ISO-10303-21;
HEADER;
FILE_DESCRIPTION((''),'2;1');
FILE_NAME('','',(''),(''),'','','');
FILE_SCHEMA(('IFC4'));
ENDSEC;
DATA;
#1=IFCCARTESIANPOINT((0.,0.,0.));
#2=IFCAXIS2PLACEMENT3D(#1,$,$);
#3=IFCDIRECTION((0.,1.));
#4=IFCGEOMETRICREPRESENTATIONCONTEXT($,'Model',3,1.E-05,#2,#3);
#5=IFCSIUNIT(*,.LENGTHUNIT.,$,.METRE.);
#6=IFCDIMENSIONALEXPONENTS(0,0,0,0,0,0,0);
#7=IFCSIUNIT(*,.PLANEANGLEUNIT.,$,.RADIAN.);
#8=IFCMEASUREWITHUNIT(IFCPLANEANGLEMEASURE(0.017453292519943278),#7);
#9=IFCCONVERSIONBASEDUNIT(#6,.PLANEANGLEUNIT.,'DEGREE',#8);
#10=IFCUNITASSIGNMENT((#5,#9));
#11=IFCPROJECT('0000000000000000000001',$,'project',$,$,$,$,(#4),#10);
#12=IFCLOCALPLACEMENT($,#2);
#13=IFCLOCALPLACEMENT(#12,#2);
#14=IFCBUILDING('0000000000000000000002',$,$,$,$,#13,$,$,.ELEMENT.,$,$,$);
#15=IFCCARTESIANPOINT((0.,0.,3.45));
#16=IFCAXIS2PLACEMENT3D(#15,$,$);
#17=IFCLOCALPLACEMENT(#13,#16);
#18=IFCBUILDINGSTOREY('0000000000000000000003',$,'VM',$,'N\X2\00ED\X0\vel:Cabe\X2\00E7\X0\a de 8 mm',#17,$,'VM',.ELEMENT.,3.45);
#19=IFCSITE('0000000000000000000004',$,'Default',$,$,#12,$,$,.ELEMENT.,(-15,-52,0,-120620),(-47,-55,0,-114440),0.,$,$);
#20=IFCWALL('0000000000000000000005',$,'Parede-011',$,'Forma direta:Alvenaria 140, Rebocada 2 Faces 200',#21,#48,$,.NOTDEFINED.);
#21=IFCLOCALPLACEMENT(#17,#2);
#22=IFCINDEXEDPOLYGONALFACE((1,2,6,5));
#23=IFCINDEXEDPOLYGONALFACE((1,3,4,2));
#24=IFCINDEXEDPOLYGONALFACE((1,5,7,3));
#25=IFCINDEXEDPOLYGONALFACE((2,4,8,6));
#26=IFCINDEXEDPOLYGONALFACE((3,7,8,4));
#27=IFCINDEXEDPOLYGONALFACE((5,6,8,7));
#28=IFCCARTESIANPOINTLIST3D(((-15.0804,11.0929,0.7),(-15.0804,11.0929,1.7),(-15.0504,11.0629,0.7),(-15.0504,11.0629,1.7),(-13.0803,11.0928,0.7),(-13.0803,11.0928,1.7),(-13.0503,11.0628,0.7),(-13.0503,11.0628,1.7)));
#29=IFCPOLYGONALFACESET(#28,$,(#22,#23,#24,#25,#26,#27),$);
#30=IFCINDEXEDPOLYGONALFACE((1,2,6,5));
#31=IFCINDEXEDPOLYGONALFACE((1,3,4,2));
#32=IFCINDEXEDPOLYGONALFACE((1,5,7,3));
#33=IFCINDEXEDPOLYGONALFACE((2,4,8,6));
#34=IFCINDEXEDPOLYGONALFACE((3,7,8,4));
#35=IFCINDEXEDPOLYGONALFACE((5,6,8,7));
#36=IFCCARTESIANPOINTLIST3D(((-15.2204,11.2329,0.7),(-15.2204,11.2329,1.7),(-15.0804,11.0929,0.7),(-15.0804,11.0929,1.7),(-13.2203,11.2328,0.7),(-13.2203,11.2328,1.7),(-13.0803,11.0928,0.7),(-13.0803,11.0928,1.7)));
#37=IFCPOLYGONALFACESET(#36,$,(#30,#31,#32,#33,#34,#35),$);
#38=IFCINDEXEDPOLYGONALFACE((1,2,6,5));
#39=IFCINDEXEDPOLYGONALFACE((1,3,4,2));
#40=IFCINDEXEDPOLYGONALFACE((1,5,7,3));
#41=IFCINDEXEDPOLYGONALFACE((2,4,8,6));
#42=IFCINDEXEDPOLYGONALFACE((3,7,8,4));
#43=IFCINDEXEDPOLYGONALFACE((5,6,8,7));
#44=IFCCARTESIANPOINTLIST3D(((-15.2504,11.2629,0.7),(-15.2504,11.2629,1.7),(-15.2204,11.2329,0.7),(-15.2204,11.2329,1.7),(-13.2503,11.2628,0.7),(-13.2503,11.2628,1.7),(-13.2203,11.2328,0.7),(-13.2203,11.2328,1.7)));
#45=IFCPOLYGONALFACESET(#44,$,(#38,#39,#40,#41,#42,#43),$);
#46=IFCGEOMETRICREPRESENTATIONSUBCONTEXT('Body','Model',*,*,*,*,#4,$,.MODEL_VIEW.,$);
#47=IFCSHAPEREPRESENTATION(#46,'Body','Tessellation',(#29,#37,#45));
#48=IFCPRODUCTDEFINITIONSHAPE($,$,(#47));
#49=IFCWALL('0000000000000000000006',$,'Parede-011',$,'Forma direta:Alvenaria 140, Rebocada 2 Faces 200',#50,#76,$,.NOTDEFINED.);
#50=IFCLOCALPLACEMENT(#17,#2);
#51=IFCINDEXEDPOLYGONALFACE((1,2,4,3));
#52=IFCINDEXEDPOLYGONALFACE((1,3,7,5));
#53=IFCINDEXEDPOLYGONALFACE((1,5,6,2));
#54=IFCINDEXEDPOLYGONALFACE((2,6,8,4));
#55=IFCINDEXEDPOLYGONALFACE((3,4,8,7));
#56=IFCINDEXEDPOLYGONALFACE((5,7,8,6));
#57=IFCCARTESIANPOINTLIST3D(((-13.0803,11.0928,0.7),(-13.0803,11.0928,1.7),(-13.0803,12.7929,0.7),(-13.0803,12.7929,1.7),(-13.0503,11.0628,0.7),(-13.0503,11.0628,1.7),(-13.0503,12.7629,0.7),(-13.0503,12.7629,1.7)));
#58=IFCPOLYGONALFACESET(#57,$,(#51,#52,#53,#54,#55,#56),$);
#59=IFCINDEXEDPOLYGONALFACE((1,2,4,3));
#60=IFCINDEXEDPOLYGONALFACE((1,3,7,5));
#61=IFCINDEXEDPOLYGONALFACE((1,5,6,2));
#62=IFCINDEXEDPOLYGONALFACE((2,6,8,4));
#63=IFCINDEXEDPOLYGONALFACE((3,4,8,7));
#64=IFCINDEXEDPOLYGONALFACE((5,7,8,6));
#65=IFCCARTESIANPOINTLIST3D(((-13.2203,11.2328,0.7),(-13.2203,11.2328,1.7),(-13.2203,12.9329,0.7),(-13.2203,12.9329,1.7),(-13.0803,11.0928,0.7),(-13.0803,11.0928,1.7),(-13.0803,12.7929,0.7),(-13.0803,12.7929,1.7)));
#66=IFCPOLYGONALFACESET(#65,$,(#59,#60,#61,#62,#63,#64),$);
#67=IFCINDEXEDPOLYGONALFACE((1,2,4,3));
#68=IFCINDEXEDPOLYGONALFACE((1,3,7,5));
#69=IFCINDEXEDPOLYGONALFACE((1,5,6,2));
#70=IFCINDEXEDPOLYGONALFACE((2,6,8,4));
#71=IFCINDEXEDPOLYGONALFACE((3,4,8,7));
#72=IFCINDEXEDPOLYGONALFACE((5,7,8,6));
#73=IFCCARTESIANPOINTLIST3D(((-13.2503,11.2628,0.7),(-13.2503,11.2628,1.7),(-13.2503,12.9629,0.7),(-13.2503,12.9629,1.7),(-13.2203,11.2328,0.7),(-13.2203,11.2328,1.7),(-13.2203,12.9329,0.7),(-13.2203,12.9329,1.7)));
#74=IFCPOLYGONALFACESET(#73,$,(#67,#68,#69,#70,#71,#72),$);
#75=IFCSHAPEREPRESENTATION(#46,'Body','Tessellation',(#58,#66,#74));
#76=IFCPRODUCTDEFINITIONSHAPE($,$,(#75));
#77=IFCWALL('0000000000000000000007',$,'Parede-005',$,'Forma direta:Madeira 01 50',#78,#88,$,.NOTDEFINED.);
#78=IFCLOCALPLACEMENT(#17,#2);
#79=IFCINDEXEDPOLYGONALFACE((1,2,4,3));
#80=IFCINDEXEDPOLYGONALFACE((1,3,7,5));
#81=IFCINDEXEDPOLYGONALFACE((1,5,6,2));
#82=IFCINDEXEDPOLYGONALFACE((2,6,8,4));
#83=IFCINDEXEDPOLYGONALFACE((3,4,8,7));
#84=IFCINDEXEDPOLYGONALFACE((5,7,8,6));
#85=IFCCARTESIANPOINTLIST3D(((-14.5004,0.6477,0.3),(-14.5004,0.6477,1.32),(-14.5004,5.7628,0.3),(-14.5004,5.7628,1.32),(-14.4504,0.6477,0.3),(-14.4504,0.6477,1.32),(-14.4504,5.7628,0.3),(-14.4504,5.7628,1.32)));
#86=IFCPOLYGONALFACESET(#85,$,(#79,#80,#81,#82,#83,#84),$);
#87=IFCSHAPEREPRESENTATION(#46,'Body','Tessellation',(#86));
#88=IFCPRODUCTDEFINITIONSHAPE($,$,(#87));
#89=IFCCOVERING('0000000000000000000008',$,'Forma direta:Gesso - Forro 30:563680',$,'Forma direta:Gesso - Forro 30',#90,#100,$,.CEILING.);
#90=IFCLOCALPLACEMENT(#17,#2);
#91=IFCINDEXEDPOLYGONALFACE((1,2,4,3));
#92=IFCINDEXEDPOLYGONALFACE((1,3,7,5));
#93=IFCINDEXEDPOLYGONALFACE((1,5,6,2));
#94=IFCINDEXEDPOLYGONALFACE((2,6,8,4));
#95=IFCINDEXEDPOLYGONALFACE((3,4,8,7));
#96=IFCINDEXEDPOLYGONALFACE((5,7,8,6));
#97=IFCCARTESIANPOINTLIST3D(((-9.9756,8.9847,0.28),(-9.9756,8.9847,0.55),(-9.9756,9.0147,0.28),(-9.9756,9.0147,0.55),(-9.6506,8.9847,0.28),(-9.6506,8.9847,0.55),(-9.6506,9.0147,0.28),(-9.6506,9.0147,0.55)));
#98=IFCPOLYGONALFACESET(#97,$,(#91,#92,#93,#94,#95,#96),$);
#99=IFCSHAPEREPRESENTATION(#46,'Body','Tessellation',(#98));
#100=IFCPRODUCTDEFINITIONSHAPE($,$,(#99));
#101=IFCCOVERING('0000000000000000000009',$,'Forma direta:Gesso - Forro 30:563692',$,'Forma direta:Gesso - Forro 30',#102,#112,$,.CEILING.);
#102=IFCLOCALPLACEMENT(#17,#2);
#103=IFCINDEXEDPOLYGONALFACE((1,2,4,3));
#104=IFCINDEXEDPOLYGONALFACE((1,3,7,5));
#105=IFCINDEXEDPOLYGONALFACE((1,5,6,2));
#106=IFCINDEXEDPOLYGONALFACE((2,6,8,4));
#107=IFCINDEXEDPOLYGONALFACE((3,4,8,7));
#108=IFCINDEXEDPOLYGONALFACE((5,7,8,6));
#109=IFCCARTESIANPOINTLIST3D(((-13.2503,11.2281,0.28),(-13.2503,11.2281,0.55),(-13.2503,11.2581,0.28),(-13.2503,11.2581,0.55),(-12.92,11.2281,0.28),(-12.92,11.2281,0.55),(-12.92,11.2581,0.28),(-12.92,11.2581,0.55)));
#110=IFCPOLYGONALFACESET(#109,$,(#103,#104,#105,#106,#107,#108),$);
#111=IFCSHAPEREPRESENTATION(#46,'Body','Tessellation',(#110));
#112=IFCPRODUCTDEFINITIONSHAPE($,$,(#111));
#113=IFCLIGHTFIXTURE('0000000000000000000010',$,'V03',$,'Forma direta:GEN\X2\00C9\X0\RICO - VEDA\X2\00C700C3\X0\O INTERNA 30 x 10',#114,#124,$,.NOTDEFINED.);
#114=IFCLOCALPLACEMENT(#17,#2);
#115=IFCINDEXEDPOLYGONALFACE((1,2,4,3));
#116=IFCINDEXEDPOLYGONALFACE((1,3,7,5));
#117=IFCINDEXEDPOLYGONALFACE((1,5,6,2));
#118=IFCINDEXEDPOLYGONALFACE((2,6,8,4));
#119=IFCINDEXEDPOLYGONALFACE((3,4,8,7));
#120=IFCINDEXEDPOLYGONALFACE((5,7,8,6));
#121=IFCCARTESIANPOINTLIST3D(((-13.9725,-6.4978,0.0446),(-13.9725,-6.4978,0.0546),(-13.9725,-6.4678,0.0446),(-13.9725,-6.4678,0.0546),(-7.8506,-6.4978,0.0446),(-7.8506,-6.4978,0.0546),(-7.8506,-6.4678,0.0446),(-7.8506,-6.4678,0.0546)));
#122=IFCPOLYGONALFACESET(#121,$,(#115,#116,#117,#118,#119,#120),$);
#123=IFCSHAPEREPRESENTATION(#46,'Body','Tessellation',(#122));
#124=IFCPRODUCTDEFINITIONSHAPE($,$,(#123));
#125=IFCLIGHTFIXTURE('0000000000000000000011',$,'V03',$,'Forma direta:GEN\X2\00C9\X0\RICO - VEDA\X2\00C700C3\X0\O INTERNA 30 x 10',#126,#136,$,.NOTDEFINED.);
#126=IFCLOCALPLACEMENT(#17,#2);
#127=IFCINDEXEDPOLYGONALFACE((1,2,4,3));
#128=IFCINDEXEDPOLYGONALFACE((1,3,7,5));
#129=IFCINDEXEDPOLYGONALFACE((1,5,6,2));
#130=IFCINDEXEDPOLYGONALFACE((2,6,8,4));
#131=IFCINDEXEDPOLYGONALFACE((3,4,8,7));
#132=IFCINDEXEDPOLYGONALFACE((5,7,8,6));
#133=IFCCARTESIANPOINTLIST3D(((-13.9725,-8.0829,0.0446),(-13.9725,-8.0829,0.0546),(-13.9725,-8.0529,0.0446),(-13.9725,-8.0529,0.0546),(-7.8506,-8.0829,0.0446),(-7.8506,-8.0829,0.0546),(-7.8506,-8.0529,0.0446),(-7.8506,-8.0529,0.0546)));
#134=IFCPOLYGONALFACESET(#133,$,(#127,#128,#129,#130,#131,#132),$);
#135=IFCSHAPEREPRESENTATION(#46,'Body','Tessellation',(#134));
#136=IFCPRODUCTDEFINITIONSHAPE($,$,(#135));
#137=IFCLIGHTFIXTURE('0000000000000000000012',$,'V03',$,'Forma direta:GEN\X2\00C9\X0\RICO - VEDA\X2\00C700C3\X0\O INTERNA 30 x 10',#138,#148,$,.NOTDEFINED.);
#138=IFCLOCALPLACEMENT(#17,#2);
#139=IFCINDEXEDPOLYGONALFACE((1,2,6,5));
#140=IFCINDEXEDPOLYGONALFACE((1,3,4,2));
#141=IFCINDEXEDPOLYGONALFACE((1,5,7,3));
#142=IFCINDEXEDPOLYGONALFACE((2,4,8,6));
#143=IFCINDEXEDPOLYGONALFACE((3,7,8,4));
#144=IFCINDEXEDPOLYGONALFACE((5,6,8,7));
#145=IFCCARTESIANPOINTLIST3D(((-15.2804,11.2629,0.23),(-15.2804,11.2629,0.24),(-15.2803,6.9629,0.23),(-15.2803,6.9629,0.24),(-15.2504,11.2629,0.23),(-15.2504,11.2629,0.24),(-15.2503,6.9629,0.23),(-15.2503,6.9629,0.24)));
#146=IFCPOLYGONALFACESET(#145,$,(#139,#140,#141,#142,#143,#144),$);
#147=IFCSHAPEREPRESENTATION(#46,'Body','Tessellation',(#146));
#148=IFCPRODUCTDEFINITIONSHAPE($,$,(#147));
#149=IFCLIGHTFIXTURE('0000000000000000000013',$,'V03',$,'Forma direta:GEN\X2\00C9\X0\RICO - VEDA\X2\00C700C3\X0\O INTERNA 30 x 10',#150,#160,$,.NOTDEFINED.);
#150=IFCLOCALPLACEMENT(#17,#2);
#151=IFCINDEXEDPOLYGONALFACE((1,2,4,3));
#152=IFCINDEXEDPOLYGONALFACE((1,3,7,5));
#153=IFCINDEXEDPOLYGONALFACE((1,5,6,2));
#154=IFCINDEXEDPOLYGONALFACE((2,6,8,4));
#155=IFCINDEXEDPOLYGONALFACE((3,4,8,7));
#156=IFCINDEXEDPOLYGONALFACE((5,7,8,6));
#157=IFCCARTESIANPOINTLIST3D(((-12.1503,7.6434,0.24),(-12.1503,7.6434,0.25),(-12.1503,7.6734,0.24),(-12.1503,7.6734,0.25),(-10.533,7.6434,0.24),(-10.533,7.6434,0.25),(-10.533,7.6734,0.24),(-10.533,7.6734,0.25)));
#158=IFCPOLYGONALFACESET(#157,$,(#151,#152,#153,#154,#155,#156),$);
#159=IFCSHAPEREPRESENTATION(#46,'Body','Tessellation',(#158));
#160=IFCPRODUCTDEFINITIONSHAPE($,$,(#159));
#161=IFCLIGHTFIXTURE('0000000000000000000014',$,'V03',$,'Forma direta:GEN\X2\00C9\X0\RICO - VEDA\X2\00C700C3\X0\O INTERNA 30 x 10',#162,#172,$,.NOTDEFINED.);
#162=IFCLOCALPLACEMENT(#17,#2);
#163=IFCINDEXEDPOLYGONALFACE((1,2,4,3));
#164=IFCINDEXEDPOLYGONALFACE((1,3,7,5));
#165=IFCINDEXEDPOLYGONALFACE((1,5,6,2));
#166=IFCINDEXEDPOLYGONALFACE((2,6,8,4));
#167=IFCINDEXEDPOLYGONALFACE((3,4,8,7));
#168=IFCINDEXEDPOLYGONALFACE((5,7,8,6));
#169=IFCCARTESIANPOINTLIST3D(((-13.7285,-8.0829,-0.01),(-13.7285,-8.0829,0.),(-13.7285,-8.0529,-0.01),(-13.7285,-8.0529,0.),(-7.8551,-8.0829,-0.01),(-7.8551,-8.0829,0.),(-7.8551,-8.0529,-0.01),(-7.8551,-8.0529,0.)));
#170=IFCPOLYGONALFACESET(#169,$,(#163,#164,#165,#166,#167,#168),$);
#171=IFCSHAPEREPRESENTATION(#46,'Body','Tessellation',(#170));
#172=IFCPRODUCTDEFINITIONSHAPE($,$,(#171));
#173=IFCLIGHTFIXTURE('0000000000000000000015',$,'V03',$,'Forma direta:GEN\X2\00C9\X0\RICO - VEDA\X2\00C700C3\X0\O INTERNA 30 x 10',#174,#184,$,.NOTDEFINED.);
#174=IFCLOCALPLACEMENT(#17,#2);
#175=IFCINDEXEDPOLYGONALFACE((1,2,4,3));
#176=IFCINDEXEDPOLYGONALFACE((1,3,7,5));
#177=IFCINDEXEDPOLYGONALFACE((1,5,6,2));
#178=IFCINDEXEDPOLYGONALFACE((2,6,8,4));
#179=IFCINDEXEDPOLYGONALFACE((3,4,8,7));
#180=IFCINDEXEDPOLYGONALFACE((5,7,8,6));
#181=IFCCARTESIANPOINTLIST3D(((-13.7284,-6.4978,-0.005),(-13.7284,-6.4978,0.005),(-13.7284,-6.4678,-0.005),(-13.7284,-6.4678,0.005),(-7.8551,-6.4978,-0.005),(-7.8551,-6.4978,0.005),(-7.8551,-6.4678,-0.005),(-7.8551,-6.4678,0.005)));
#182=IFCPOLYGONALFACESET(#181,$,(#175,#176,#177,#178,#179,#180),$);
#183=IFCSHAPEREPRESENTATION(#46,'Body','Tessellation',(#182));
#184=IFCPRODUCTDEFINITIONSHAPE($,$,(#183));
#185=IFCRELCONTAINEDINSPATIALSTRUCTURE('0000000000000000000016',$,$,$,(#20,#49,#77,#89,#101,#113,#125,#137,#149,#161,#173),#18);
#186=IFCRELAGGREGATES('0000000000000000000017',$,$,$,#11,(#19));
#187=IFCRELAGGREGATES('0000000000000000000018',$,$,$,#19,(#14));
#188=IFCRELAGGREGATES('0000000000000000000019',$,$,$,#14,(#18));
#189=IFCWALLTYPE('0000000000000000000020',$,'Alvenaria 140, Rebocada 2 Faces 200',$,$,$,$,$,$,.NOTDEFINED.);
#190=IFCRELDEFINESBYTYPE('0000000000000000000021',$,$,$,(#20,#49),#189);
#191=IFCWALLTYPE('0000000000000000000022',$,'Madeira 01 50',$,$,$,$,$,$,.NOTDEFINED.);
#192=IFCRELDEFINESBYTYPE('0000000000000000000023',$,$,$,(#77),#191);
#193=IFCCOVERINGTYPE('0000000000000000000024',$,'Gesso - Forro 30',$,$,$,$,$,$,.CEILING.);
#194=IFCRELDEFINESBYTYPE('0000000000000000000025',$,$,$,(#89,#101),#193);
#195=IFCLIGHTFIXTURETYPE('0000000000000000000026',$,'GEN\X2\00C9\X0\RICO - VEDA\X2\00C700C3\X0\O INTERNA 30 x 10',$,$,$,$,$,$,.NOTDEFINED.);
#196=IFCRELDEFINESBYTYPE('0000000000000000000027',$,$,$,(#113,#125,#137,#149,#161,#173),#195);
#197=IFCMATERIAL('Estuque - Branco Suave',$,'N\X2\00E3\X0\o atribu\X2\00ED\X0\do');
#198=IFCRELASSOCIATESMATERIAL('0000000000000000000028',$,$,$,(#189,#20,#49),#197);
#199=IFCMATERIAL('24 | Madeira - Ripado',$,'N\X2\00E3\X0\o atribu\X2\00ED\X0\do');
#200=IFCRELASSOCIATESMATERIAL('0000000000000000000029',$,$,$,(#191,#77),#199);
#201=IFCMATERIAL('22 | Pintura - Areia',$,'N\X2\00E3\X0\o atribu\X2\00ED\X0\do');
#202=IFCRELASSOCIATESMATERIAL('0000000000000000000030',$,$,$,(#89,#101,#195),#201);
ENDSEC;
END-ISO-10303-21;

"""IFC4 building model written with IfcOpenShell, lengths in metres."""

from ifc_helpers import new_model, entity, si_unit, converted_unit, direction, frame, origin, place, context, subcontext, project, spatial, indexed_curve, outline, extrude, material, type_object, element, save


model = new_model("IFC4")

# Units and contexts
model_context = context("Model", 3, precision=1e-05, world=origin(), true_north=direction((0.0, 1.0)))
body_context = subcontext(model_context, "Body", "Model", "MODEL_VIEW")
ifc_project = project(units=[si_unit("LENGTHUNIT", "METRE"), converted_unit("PLANEANGLEUNIT", "DEGREE", entity("IfcPlaneAngleMeasure", 0.017453292519943278), si_unit("PLANEANGLEUNIT", "RADIAN"), dimensions=[0, 0, 0, 0, 0, 0, 0])], contexts=[model_context])

# Site, building, storey
site_placement = place(None, origin())
site = spatial("IfcSite", under=ifc_project, at=site_placement, Name="Default", CompositionType="ELEMENT", RefLatitude=(-15, -52, 0, -120620), RefLongitude=(-47, -55, 0, -114440), RefElevation=0.0)
building_placement = place(site_placement, origin())
building = spatial("IfcBuilding", under=site, at=building_placement, CompositionType="ELEMENT")
storey_placement = place(building_placement, frame((0.0, 0.0, 3.45)))
storey = spatial("IfcBuildingStorey", under=building, at=storey_placement, Name="VM", ObjectType="Nível:Cabeça de 8 mm", LongName="VM", CompositionType="ELEMENT", Elevation=3.45)

# Walls
ifc_material_1 = material(Name="Estuque - Branco Suave", Category="Não atribuído")
wall_type_1 = type_object("IfcWallType", Name="Alvenaria 140, Rebocada 2 Faces 200", PredefinedType="NOTDEFINED", material=ifc_material_1)
wall_1_placement = place(storey_placement, frame((-15.2504, 11.0628, 0.7)))
element("IfcWall", 1, at=wall_1_placement, inside=storey, type_object=wall_type_1, material=ifc_material_1, Name="Parede-011", ObjectType="Forma direta:Alvenaria 140, Rebocada 2 Faces 200", PredefinedType="NOTDEFINED", context=body_context, shape_type="SweptSolid", body=[
    extrude(outline(indexed_curve([(-0.7283, -0.7071), (-0.6859, -0.7071), (0.7283, 0.7071), (0.6859, 0.7071), (-0.7283, -0.7071)], self_intersect=False)), frame((1.185, 0.015, 0.0), z_axis=(0.0, 0.0, 1.0), x_axis=(0.707102, -0.707111, 0.0)), (0.0, 0.0, 1.0), 1.0),
    extrude(outline(indexed_curve([(-0.8061, -0.7071), (-0.6081, -0.7071), (0.8061, 0.7071), (0.6081, 0.7071), (-0.8061, -0.7071)], self_intersect=False)), frame((1.1, 0.1, 0.0), z_axis=(0.0, 0.0, 1.0), x_axis=(-0.707098, 0.707116, 0.0)), (0.0, 0.0, 1.0), 1.0),
    extrude(outline(indexed_curve([(-0.7283, -0.7071), (-0.6859, -0.7071), (0.7283, 0.7071), (0.6859, 0.7071), (-0.7283, -0.7071)], self_intersect=False)), frame((1.015, 0.185, 0.0), z_axis=(0.0, 0.0, 1.0), x_axis=(-0.707098, 0.707116, 0.0)), (0.0, 0.0, 1.0), 1.0),
])
wall_2_placement = place(storey_placement, frame((-13.2503, 11.0628, 0.7), z_axis=(0.0, 0.0, 1.0), x_axis=(0.0, 1.0, 0.0)))
element("IfcWall", 2, at=wall_2_placement, inside=storey, type_object=wall_type_1, material=ifc_material_1, Name="Parede-011", ObjectType="Forma direta:Alvenaria 140, Rebocada 2 Faces 200", PredefinedType="NOTDEFINED", context=body_context, shape_type="SweptSolid", body=[
    extrude(outline(indexed_curve([(0.5798, -0.6011), (0.6223, -0.6011), (-0.5798, 0.6011), (-0.6223, 0.6011), (0.5798, -0.6011)], self_intersect=False)), frame((0.865, -0.185, 0.0), z_axis=(0.0, 0.0, 1.0), x_axis=(-0.707116, -0.707098, 0.0)), (0.0, 0.0, 1.0), 1.0),
    extrude(outline(indexed_curve([(0.5021, -0.6011), (0.7001, -0.6011), (-0.5021, 0.6011), (-0.7001, 0.6011), (0.5021, -0.6011)], self_intersect=False)), frame((0.95, -0.1, 0.0), z_axis=(0.0, 0.0, 1.0), x_axis=(0.707116, 0.707098, 0.0)), (0.0, 0.0, 1.0), 1.0),
    extrude(outline(indexed_curve([(0.5798, -0.6011), (0.6223, -0.6011), (-0.5798, 0.6011), (-0.6223, 0.6011), (0.5798, -0.6011)], self_intersect=False)), frame((1.035, -0.015, 0.0), z_axis=(0.0, 0.0, 1.0), x_axis=(0.707116, 0.707098, 0.0)), (0.0, 0.0, 1.0), 1.0),
])
ifc_material_2 = material(Name="24 | Madeira - Ripado", Category="Não atribuído")
wall_type_2 = type_object("IfcWallType", Name="Madeira 01 50", PredefinedType="NOTDEFINED", material=ifc_material_2)
wall_3_placement = place(storey_placement, frame((-14.5004, 0.6477, 0.3), z_axis=(0.0, 0.0, 1.0), x_axis=(0.0, 1.0, 0.0)))
element("IfcWall", 3, at=wall_3_placement, inside=storey, type_object=wall_type_2, material=ifc_material_2, Name="Parede-005", ObjectType="Forma direta:Madeira 01 50", PredefinedType="NOTDEFINED", context=body_context, shape_type="SweptSolid", body=[
    extrude(outline(indexed_curve([(-0.025, -2.5576), (0.025, -2.5576), (0.025, 2.5576), (-0.025, 2.5576), (-0.025, -2.5576)], self_intersect=False)), frame((2.5576, -0.025, 0.0), z_axis=(0.0, 0.0, 1.0), x_axis=(-0.000013, -1.0, 0.0)), (0.0, 0.0, 1.0), 1.02),
])

# Coverings
ifc_material_3 = material(Name="22 | Pintura - Areia", Category="Não atribuído")
covering_type = type_object("IfcCoveringType", Name="Gesso - Forro 30", PredefinedType="CEILING")
covering_1_placement = place(storey_placement, origin())
element("IfcCovering", 4, at=covering_1_placement, inside=storey, type_object=covering_type, material=ifc_material_3, Name="Forma direta:Gesso - Forro 30:563680", ObjectType="Forma direta:Gesso - Forro 30", PredefinedType="CEILING", context=body_context, shape_type="SweptSolid", body=[
    extrude(outline(indexed_curve([(-0.015, -0.1625), (0.015, -0.1625), (0.015, 0.1625), (-0.015, 0.1625), (-0.015, -0.1625)], self_intersect=False)), frame((-9.8131, 8.9997, 0.28), z_axis=(0.0, 0.0, 1.0), x_axis=(0.000013, 1.0, 0.0)), (0.0, 0.0, 1.0), 0.27),
])
covering_2_placement = place(storey_placement, origin())
element("IfcCovering", 5, at=covering_2_placement, inside=storey, type_object=covering_type, material=ifc_material_3, Name="Forma direta:Gesso - Forro 30:563692", ObjectType="Forma direta:Gesso - Forro 30", PredefinedType="CEILING", context=body_context, shape_type="SweptSolid", body=[
    extrude(outline(indexed_curve([(-0.015, -0.1652), (0.015, -0.1652), (0.015, 0.1652), (-0.015, 0.1652), (-0.015, -0.1652)], self_intersect=False)), frame((-13.0851, 11.2431, 0.28), z_axis=(0.0, 0.0, 1.0), x_axis=(0.000002, -1.0, 0.0)), (0.0, 0.0, 1.0), 0.27),
])

# Light fixtures
light_fixture_type_1 = type_object("IfcLightFixtureType", Name="GENÉRICO - VEDAÇÃO INTERNA 30 x 10", PredefinedType="NOTDEFINED", material=ifc_material_3)
light_fixture_1_placement = place(storey_placement, origin())
element("IfcLightFixture", 6, at=light_fixture_1_placement, inside=storey, type_object=light_fixture_type_1, Name="V03", ObjectType="Forma direta:GENÉRICO - VEDAÇÃO INTERNA 30 x 10", PredefinedType="NOTDEFINED", context=body_context, shape_type="SweptSolid", body=[
    extrude(outline(indexed_curve([(-3.061, -0.015), (3.061, -0.015), (3.061, 0.015), (-3.061, 0.015), (-3.061, -0.015)], self_intersect=False)), frame((-10.9115, -6.4828, 0.0446)), (0.0, 0.0, 1.0), 0.01),
])
light_fixture_2_placement = place(storey_placement, origin())
element("IfcLightFixture", 7, at=light_fixture_2_placement, inside=storey, type_object=light_fixture_type_1, Name="V03", ObjectType="Forma direta:GENÉRICO - VEDAÇÃO INTERNA 30 x 10", PredefinedType="NOTDEFINED", context=body_context, shape_type="SweptSolid", body=[
    extrude(outline(indexed_curve([(-3.061, -0.015), (3.061, -0.015), (3.061, 0.015), (-3.061, 0.015), (-3.061, -0.015)], self_intersect=False)), frame((-10.9116, -8.0679, 0.0446)), (0.0, 0.0, 1.0), 0.01),
])
light_fixture_3_placement = place(storey_placement, origin())
element("IfcLightFixture", 8, at=light_fixture_3_placement, inside=storey, type_object=light_fixture_type_1, Name="V03", ObjectType="Forma direta:GENÉRICO - VEDAÇÃO INTERNA 30 x 10", PredefinedType="NOTDEFINED", context=body_context, shape_type="SweptSolid", body=[
    extrude(outline(indexed_curve([(-2.15, -0.015), (2.15, -0.015), (2.15, 0.015), (-2.15, 0.015), (-2.15, -0.015)], self_intersect=False)), frame((-15.2654, 9.1129, 0.23), z_axis=(0.0, 0.0, 1.0), x_axis=(-0.000001, 1.0, 0.0)), (0.0, 0.0, 1.0), 0.01),
])
light_fixture_4_placement = place(storey_placement, origin())
element("IfcLightFixture", 9, at=light_fixture_4_placement, inside=storey, type_object=light_fixture_type_1, Name="V03", ObjectType="Forma direta:GENÉRICO - VEDAÇÃO INTERNA 30 x 10", PredefinedType="NOTDEFINED", context=body_context, shape_type="SweptSolid", body=[
    extrude(outline(indexed_curve([(-0.8087, -0.015), (0.8087, -0.015), (0.8087, 0.015), (-0.8087, 0.015), (-0.8087, -0.015)], self_intersect=False)), frame((-11.3417, 7.6584, 0.24)), (0.0, 0.0, 1.0), 0.01),
])
light_fixture_5_placement = place(storey_placement, origin())
element("IfcLightFixture", 10, at=light_fixture_5_placement, inside=storey, type_object=light_fixture_type_1, Name="V03", ObjectType="Forma direta:GENÉRICO - VEDAÇÃO INTERNA 30 x 10", PredefinedType="NOTDEFINED", context=body_context, shape_type="SweptSolid", body=[
    extrude(outline(indexed_curve([(-2.9367, -0.015), (2.9367, -0.015), (2.9367, 0.015), (-2.9367, 0.015), (-2.9367, -0.015)], self_intersect=False)), frame((-10.7918, -8.0679, -0.01)), (0.0, 0.0, 1.0), 0.01),
])
light_fixture_6_placement = place(storey_placement, origin())
element("IfcLightFixture", 11, at=light_fixture_6_placement, inside=storey, type_object=light_fixture_type_1, Name="V03", ObjectType="Forma direta:GENÉRICO - VEDAÇÃO INTERNA 30 x 10", PredefinedType="NOTDEFINED", context=body_context, shape_type="SweptSolid", body=[
    extrude(outline(indexed_curve([(-2.9367, -0.015), (2.9367, -0.015), (2.9367, 0.015), (-2.9367, 0.015), (-2.9367, -0.015)], self_intersect=False)), frame((-10.7918, -6.4828, -0.005)), (0.0, 0.0, 1.0), 0.01),
])

save(model, "model.ifc")
